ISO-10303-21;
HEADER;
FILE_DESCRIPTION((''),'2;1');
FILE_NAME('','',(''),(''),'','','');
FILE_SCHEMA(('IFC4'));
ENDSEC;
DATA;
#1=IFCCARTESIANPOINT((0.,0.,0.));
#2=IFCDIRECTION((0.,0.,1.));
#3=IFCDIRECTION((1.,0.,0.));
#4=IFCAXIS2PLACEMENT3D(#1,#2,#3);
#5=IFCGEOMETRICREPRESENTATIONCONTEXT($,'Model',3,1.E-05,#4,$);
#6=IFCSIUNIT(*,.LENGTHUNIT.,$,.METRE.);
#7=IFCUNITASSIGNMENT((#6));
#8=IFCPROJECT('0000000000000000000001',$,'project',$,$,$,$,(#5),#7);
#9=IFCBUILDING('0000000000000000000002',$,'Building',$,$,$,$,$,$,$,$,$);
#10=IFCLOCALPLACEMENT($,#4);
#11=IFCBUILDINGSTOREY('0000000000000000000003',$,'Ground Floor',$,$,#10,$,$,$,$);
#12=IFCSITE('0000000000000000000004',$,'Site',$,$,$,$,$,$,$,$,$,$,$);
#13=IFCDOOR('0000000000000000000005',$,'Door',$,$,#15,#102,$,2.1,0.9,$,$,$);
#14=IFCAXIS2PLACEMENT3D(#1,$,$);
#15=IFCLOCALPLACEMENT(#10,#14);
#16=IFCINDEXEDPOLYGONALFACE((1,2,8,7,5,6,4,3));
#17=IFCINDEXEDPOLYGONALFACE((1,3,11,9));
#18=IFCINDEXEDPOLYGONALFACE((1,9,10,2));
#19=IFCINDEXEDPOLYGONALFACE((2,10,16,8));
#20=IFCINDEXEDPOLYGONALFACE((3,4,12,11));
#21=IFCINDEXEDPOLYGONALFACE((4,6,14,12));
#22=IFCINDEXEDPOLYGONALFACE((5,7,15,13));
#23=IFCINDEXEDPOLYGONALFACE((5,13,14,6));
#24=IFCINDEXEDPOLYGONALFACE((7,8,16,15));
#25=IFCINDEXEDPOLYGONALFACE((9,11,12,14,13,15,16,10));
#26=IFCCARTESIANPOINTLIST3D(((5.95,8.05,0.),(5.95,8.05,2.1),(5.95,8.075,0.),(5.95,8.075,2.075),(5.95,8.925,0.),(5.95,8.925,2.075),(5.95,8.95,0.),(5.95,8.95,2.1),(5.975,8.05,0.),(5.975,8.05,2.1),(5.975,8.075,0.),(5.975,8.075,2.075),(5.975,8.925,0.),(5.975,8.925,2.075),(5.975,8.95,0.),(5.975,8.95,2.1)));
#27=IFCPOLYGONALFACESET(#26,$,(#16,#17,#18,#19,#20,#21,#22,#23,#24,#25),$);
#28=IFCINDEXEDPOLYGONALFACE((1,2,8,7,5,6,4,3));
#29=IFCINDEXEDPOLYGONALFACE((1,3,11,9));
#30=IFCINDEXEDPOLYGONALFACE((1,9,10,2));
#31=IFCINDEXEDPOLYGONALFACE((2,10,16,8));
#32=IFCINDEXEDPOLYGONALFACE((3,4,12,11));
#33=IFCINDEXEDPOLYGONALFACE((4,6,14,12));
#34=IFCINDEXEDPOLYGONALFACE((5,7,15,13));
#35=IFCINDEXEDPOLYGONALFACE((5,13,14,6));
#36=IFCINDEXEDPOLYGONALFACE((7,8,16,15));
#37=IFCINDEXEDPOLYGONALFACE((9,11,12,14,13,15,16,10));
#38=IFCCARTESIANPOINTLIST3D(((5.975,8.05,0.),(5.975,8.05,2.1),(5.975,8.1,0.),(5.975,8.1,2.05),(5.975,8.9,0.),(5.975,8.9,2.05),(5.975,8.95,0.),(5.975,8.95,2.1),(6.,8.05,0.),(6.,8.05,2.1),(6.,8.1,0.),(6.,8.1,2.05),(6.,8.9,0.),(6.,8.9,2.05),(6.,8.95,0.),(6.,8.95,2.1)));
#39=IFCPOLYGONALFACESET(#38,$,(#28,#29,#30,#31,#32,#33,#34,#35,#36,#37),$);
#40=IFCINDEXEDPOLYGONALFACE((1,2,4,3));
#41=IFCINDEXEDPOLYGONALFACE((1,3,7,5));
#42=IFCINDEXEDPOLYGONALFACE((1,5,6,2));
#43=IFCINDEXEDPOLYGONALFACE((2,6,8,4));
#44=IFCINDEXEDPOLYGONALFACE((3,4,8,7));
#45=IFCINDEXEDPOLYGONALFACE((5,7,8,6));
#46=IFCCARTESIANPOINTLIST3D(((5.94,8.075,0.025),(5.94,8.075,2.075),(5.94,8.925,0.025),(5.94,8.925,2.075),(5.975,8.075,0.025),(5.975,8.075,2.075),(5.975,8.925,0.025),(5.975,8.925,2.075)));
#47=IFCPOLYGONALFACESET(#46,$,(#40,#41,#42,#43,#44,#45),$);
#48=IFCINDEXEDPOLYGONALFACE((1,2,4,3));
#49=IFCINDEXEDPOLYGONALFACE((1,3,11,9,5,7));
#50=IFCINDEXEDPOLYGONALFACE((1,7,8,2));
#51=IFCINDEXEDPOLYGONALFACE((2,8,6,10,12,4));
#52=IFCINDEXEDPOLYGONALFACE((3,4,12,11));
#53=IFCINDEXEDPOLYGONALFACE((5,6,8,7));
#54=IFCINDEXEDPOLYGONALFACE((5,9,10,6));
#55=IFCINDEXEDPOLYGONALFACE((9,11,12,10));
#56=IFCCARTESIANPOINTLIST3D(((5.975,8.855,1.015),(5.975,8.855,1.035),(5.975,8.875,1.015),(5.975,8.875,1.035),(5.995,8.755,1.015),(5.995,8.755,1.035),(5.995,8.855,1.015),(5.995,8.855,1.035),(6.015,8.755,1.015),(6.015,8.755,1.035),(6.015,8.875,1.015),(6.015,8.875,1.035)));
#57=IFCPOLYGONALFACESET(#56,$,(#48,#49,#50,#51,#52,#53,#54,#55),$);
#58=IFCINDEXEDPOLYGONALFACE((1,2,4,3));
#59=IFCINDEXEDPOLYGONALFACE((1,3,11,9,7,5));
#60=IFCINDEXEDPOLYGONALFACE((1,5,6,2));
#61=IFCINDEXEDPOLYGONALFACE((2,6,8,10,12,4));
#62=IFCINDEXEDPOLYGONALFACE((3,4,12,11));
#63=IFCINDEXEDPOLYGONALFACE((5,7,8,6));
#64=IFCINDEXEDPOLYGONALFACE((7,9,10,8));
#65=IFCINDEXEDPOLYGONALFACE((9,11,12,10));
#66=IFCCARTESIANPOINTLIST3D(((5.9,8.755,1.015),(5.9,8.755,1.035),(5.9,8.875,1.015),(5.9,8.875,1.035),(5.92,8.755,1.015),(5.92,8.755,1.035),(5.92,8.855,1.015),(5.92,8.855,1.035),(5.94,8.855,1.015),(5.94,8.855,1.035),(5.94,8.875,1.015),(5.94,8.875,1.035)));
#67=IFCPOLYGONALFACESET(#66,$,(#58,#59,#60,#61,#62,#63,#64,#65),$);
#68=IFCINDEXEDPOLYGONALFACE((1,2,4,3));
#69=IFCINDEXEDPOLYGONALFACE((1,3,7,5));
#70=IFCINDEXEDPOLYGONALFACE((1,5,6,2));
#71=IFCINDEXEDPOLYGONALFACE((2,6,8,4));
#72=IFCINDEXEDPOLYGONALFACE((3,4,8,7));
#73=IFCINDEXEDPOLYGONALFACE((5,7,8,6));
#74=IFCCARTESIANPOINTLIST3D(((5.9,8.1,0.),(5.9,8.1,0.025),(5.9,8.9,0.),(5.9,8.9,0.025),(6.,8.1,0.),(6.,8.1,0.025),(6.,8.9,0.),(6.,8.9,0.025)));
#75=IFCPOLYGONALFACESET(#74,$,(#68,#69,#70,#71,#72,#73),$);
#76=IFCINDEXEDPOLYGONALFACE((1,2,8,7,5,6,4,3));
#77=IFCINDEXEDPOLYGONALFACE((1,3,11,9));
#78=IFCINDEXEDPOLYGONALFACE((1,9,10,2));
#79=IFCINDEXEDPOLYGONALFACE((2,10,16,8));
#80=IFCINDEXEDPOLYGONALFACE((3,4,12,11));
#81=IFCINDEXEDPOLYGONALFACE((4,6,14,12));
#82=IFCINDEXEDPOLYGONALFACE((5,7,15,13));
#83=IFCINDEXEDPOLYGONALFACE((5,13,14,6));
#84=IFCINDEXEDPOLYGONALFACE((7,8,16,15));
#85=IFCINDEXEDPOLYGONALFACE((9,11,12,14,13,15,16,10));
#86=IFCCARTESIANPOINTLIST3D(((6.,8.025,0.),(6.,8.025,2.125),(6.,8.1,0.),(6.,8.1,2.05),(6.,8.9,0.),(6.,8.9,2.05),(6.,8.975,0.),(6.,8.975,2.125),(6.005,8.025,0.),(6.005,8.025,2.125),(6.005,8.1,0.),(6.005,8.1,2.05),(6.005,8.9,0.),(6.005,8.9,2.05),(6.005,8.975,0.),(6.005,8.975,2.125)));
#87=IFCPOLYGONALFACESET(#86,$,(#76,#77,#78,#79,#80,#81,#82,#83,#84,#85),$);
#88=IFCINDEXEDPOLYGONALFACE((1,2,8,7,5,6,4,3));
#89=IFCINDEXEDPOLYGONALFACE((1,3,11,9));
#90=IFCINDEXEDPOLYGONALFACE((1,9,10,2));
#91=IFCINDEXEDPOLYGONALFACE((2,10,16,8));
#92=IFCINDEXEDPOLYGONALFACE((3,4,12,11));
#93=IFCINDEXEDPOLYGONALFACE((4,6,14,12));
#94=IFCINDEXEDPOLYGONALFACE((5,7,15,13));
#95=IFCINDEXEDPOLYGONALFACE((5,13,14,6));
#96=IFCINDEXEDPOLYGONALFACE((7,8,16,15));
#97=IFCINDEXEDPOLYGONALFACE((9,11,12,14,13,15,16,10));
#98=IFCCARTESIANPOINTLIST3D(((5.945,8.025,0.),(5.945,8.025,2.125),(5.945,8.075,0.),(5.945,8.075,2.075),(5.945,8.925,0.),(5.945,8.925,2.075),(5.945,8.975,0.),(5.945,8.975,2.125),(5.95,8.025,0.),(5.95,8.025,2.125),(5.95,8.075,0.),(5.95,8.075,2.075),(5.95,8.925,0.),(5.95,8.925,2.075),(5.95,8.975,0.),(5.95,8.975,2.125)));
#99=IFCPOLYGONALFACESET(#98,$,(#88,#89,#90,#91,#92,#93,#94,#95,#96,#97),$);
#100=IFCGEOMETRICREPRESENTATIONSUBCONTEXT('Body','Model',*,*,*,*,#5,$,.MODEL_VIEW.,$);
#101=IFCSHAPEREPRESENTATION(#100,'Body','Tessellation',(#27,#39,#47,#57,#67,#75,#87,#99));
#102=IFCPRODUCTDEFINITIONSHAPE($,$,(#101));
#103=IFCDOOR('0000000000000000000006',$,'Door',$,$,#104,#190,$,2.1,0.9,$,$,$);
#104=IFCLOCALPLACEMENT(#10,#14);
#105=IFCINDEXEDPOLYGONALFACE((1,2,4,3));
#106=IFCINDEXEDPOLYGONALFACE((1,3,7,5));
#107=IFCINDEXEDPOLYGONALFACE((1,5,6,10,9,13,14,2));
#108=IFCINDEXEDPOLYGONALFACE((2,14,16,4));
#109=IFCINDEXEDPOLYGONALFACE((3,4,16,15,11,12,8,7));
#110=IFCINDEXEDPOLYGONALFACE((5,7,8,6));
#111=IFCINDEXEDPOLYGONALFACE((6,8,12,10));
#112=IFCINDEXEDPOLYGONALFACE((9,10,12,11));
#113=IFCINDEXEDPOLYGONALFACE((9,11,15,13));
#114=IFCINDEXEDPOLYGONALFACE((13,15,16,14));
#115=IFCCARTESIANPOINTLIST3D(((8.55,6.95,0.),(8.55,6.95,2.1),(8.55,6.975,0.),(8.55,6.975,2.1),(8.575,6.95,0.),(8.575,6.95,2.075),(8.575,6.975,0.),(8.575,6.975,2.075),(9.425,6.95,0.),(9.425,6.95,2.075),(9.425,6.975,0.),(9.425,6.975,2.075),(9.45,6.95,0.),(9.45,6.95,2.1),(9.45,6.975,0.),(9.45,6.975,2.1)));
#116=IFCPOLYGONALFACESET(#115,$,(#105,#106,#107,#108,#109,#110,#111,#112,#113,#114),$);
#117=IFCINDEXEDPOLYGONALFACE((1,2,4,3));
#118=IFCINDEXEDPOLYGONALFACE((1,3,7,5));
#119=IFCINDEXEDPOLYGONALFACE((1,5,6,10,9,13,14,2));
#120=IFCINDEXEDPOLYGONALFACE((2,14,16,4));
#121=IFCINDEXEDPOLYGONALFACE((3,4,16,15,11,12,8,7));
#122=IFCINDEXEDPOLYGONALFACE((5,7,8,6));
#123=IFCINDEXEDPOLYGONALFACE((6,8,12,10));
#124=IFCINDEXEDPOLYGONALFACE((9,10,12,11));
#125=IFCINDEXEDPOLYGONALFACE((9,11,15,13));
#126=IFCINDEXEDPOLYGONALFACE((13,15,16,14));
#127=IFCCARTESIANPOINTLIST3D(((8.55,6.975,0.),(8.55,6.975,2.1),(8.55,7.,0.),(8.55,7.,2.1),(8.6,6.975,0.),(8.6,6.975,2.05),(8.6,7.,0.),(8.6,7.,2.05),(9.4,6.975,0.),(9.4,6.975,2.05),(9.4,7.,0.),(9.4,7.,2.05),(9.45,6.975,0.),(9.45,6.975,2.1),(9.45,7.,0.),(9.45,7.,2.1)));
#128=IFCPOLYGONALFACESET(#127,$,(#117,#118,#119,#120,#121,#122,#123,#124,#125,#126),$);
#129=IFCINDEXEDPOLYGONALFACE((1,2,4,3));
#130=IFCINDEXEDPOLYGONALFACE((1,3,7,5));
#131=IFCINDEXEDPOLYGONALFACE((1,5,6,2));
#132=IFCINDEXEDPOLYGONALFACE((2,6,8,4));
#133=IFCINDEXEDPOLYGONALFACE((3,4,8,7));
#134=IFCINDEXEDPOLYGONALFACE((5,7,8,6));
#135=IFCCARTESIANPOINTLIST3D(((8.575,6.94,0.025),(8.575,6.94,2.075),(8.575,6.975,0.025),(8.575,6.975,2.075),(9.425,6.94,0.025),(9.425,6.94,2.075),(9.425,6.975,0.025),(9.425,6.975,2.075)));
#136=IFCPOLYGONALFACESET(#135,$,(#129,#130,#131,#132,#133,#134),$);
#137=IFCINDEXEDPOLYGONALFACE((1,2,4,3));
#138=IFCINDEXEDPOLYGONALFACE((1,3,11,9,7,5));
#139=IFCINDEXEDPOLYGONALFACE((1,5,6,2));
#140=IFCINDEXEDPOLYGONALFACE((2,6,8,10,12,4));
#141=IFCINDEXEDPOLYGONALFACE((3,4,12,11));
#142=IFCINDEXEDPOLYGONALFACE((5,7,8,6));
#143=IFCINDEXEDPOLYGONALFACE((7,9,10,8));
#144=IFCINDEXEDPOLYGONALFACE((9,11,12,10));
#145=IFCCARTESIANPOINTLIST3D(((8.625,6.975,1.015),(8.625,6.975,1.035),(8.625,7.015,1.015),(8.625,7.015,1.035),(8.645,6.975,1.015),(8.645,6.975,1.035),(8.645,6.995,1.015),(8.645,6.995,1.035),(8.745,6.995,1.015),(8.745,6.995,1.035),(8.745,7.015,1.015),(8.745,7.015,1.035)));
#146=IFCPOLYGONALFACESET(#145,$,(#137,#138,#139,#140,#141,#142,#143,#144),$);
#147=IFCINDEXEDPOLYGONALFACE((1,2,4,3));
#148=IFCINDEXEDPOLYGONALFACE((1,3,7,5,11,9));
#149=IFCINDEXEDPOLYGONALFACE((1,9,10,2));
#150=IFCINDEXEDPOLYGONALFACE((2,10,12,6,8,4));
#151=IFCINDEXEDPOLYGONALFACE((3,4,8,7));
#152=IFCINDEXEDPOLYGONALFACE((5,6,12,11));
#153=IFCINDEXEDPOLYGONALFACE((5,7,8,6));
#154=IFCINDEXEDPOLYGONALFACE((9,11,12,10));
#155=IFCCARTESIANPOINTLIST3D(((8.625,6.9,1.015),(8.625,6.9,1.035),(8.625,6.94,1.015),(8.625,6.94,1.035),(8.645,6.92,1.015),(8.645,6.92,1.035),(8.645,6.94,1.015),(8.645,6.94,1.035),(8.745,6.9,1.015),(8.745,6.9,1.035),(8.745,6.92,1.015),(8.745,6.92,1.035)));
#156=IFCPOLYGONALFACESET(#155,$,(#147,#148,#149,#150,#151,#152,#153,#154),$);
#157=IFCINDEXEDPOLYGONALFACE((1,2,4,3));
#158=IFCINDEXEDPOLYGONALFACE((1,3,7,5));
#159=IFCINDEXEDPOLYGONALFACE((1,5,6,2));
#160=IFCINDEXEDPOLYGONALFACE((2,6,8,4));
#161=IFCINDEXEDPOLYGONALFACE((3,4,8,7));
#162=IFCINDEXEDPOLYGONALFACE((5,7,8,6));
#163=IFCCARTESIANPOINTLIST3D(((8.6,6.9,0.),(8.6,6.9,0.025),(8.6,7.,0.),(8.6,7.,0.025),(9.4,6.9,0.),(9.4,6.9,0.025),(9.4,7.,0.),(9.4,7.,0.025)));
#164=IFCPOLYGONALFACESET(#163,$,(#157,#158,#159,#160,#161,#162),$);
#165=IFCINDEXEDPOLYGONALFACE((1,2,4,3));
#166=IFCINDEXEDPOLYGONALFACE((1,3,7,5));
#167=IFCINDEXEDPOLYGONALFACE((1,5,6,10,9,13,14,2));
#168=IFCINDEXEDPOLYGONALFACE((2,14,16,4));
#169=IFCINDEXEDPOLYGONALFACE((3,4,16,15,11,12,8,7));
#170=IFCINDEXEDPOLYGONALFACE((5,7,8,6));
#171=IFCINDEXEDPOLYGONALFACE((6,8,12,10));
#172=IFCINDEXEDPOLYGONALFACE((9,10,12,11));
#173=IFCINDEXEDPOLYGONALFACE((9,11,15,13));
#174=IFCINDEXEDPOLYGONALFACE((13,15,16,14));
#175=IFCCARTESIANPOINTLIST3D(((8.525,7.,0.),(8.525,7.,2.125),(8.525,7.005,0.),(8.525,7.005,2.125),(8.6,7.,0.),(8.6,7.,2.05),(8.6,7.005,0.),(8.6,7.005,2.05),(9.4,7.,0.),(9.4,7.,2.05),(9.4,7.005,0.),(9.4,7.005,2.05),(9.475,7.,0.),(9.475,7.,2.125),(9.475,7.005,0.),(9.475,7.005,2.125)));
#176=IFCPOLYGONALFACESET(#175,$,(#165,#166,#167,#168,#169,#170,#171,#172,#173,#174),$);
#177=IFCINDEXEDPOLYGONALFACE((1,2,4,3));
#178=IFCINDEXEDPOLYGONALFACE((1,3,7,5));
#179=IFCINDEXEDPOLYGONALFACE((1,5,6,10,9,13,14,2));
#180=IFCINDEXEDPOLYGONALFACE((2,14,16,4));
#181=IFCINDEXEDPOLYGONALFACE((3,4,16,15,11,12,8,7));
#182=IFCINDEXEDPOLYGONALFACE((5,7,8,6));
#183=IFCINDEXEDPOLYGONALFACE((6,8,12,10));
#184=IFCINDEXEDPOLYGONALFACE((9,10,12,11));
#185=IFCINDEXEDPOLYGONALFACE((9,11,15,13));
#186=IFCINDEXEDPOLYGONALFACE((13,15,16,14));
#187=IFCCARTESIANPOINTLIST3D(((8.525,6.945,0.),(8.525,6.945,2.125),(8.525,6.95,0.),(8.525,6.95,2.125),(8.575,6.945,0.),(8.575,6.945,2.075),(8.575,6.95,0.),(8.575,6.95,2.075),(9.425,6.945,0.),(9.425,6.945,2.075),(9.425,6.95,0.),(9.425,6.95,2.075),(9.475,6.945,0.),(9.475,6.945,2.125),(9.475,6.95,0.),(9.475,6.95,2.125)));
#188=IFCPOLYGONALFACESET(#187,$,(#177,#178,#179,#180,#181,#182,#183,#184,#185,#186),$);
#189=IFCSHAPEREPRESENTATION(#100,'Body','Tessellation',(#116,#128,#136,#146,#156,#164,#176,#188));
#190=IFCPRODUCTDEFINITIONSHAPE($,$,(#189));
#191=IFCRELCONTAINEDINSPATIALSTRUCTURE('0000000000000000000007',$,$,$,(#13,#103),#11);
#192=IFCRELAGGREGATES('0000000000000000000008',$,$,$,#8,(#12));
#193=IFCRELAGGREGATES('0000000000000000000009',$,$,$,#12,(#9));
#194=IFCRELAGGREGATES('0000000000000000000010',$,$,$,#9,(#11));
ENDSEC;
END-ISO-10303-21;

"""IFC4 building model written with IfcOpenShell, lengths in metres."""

from ifc_helpers import new_model, si_unit, frame, origin_with_axes, place, context, subcontext, project, spatial, line, indexed_curve, outline, extrude, element, save


model = new_model("IFC4")

# Units and contexts
model_context = context("Model", 3, precision=1e-05, world=origin_with_axes())
body_context = subcontext(model_context, "Body", "Model", "MODEL_VIEW")
ifc_project = project(units=[si_unit("LENGTHUNIT", "METRE")], contexts=[model_context])

# Site, building, storey
site = spatial("IfcSite", under=ifc_project, Name="Site")
building = spatial("IfcBuilding", under=site, Name="Building")
storey_placement = place(None, origin_with_axes())
storey = spatial("IfcBuildingStorey", under=building, at=storey_placement, Name="Ground Floor")

# Doors
door_1_placement = place(storey_placement, frame((6.0, 8.05, 0.0), z_axis=(0.0, 0.0, 1.0), x_axis=(0.0, 1.0, 0.0)))
element("IfcDoor", 1, at=door_1_placement, inside=storey, Name="Door", OverallHeight=2.1, OverallWidth=0.9, context=body_context, shape_type="SweptSolid", body=[
    extrude(outline(indexed_curve([(0.0, 0.0), (0.0, 2.1), (0.9, 2.1), (0.9, 0.0), (0.875, 0.0), (0.875, 2.075), (0.025, 2.075), (0.025, 0.0)], segments=[line(1, 2, 3, 4, 5, 6, 7, 8, 1)])), frame((0.0, 0.025, 0.0), z_axis=(0.0, -1.0, 0.0), x_axis=(1.0, 0.0, 0.0)), (0.0, 0.0, -1.0), 0.025),
    extrude(outline(indexed_curve([(0.0, 0.0), (0.0, 2.1), (0.9, 2.1), (0.9, 0.0), (0.85, 0.0), (0.85, 2.05), (0.05, 2.05), (0.05, 0.0)], segments=[line(1, 2, 3, 4, 5, 6, 7, 8, 1)])), frame((0.0, 0.0, 0.0), z_axis=(0.0, -1.0, 0.0), x_axis=(1.0, 0.0, 0.0)), (0.0, 0.0, -1.0), 0.025),
    extrude(outline(indexed_curve([(0.0, 0.0), (0.85, 0.0), (0.85, 0.035), (0.0, 0.035)], segments=[line(1, 2, 3, 4, 1)])), frame((0.025, 0.025, 0.025), z_axis=(0.0, 0.0, 1.0), x_axis=(1.0, 0.0, 0.0)), (0.0, 0.0, 1.0), 2.05),
    extrude(outline(indexed_curve([(0.0, 0.0), (0.0, -0.04), (-0.12, -0.04), (-0.12, -0.02), (-0.02, -0.02), (-0.02, 0.0)], segments=[line(1, 2, 3, 4, 5, 6, 1)])), frame((0.825, 0.025, 1.015), z_axis=(0.0, 0.0, 1.0), x_axis=(1.0, 0.0, 0.0)), (0.0, 0.0, 1.0), 0.02),
    extrude(outline(indexed_curve([(0.0, 0.0), (0.0, 0.04), (-0.12, 0.04), (-0.12, 0.02), (-0.02, 0.02), (-0.02, 0.0)], segments=[line(1, 2, 3, 4, 5, 6, 1)])), frame((0.825, 0.06, 1.015), z_axis=(0.0, 0.0, 1.0), x_axis=(1.0, 0.0, 0.0)), (0.0, 0.0, 1.0), 0.02),
    extrude(outline(indexed_curve([(0.0, 0.0), (0.8, 0.0), (0.8, 0.1), (0.0, 0.1)], segments=[line(1, 2, 3, 4, 1)])), frame((0.05, 0.0, 0.0), z_axis=(0.0, 0.0, 1.0), x_axis=(1.0, 0.0, 0.0)), (0.0, 0.0, 1.0), 0.025),
    extrude(outline(indexed_curve([(0.0, 0.0), (0.0, 2.125), (0.95, 2.125), (0.95, 0.0), (0.875, 0.0), (0.875, 2.05), (0.075, 2.05), (0.075, 0.0)], segments=[line(1, 2, 3, 4, 5, 6, 7, 8, 1)])), frame((-0.025, -0.005, 0.0), z_axis=(0.0, -1.0, 0.0), x_axis=(1.0, 0.0, 0.0)), (0.0, 0.0, -1.0), 0.005),
    extrude(outline(indexed_curve([(0.0, 0.0), (0.0, 2.125), (0.95, 2.125), (0.95, 0.0), (0.9, 0.0), (0.9, 2.075), (0.05, 2.075), (0.05, 0.0)], segments=[line(1, 2, 3, 4, 5, 6, 7, 8, 1)])), frame((-0.025, 0.05, 0.0), z_axis=(0.0, -1.0, 0.0), x_axis=(1.0, 0.0, 0.0)), (0.0, 0.0, -1.0), 0.005),
])
door_2_placement = place(storey_placement, frame((9.45, 7.0, 0.0), z_axis=(0.0, 0.0, 1.0), x_axis=(-1.0, 0.0, 0.0)))
element("IfcDoor", 2, at=door_2_placement, inside=storey, Name="Door", OverallHeight=2.1, OverallWidth=0.9, context=body_context, shape_type="SweptSolid", body=[
    extrude(outline(indexed_curve([(0.0, 0.0), (0.0, 2.1), (0.9, 2.1), (0.9, 0.0), (0.875, 0.0), (0.875, 2.075), (0.025, 2.075), (0.025, 0.0)], segments=[line(1, 2, 3, 4, 5, 6, 7, 8, 1)])), frame((0.0, 0.025, 0.0), z_axis=(0.0, -1.0, 0.0), x_axis=(1.0, 0.0, 0.0)), (0.0, 0.0, -1.0), 0.025),
    extrude(outline(indexed_curve([(0.0, 0.0), (0.0, 2.1), (0.9, 2.1), (0.9, 0.0), (0.85, 0.0), (0.85, 2.05), (0.05, 2.05), (0.05, 0.0)], segments=[line(1, 2, 3, 4, 5, 6, 7, 8, 1)])), frame((0.0, 0.0, 0.0), z_axis=(0.0, -1.0, 0.0), x_axis=(1.0, 0.0, 0.0)), (0.0, 0.0, -1.0), 0.025),
    extrude(outline(indexed_curve([(0.0, 0.0), (0.85, 0.0), (0.85, 0.035), (0.0, 0.035)], segments=[line(1, 2, 3, 4, 1)])), frame((0.025, 0.025, 0.025), z_axis=(0.0, 0.0, 1.0), x_axis=(1.0, 0.0, 0.0)), (0.0, 0.0, 1.0), 2.05),
    extrude(outline(indexed_curve([(0.0, 0.0), (0.0, -0.04), (-0.12, -0.04), (-0.12, -0.02), (-0.02, -0.02), (-0.02, 0.0)], segments=[line(1, 2, 3, 4, 5, 6, 1)])), frame((0.825, 0.025, 1.015), z_axis=(0.0, 0.0, 1.0), x_axis=(1.0, 0.0, 0.0)), (0.0, 0.0, 1.0), 0.02),
    extrude(outline(indexed_curve([(0.0, 0.0), (0.0, 0.04), (-0.12, 0.04), (-0.12, 0.02), (-0.02, 0.02), (-0.02, 0.0)], segments=[line(1, 2, 3, 4, 5, 6, 1)])), frame((0.825, 0.06, 1.015), z_axis=(0.0, 0.0, 1.0), x_axis=(1.0, 0.0, 0.0)), (0.0, 0.0, 1.0), 0.02),
    extrude(outline(indexed_curve([(0.0, 0.0), (0.8, 0.0), (0.8, 0.1), (0.0, 0.1)], segments=[line(1, 2, 3, 4, 1)])), frame((0.05, 0.0, 0.0), z_axis=(0.0, 0.0, 1.0), x_axis=(1.0, 0.0, 0.0)), (0.0, 0.0, 1.0), 0.025),
    extrude(outline(indexed_curve([(0.0, 0.0), (0.0, 2.125), (0.95, 2.125), (0.95, 0.0), (0.875, 0.0), (0.875, 2.05), (0.075, 2.05), (0.075, 0.0)], segments=[line(1, 2, 3, 4, 5, 6, 7, 8, 1)])), frame((-0.025, -0.005, 0.0), z_axis=(0.0, -1.0, 0.0), x_axis=(1.0, 0.0, 0.0)), (0.0, 0.0, -1.0), 0.005),
    extrude(outline(indexed_curve([(0.0, 0.0), (0.0, 2.125), (0.95, 2.125), (0.95, 0.0), (0.9, 0.0), (0.9, 2.075), (0.05, 2.075), (0.05, 0.0)], segments=[line(1, 2, 3, 4, 5, 6, 7, 8, 1)])), frame((-0.025, 0.05, 0.0), z_axis=(0.0, -1.0, 0.0), x_axis=(1.0, 0.0, 0.0)), (0.0, 0.0, -1.0), 0.005),
])

save(model, "model.ifc")
